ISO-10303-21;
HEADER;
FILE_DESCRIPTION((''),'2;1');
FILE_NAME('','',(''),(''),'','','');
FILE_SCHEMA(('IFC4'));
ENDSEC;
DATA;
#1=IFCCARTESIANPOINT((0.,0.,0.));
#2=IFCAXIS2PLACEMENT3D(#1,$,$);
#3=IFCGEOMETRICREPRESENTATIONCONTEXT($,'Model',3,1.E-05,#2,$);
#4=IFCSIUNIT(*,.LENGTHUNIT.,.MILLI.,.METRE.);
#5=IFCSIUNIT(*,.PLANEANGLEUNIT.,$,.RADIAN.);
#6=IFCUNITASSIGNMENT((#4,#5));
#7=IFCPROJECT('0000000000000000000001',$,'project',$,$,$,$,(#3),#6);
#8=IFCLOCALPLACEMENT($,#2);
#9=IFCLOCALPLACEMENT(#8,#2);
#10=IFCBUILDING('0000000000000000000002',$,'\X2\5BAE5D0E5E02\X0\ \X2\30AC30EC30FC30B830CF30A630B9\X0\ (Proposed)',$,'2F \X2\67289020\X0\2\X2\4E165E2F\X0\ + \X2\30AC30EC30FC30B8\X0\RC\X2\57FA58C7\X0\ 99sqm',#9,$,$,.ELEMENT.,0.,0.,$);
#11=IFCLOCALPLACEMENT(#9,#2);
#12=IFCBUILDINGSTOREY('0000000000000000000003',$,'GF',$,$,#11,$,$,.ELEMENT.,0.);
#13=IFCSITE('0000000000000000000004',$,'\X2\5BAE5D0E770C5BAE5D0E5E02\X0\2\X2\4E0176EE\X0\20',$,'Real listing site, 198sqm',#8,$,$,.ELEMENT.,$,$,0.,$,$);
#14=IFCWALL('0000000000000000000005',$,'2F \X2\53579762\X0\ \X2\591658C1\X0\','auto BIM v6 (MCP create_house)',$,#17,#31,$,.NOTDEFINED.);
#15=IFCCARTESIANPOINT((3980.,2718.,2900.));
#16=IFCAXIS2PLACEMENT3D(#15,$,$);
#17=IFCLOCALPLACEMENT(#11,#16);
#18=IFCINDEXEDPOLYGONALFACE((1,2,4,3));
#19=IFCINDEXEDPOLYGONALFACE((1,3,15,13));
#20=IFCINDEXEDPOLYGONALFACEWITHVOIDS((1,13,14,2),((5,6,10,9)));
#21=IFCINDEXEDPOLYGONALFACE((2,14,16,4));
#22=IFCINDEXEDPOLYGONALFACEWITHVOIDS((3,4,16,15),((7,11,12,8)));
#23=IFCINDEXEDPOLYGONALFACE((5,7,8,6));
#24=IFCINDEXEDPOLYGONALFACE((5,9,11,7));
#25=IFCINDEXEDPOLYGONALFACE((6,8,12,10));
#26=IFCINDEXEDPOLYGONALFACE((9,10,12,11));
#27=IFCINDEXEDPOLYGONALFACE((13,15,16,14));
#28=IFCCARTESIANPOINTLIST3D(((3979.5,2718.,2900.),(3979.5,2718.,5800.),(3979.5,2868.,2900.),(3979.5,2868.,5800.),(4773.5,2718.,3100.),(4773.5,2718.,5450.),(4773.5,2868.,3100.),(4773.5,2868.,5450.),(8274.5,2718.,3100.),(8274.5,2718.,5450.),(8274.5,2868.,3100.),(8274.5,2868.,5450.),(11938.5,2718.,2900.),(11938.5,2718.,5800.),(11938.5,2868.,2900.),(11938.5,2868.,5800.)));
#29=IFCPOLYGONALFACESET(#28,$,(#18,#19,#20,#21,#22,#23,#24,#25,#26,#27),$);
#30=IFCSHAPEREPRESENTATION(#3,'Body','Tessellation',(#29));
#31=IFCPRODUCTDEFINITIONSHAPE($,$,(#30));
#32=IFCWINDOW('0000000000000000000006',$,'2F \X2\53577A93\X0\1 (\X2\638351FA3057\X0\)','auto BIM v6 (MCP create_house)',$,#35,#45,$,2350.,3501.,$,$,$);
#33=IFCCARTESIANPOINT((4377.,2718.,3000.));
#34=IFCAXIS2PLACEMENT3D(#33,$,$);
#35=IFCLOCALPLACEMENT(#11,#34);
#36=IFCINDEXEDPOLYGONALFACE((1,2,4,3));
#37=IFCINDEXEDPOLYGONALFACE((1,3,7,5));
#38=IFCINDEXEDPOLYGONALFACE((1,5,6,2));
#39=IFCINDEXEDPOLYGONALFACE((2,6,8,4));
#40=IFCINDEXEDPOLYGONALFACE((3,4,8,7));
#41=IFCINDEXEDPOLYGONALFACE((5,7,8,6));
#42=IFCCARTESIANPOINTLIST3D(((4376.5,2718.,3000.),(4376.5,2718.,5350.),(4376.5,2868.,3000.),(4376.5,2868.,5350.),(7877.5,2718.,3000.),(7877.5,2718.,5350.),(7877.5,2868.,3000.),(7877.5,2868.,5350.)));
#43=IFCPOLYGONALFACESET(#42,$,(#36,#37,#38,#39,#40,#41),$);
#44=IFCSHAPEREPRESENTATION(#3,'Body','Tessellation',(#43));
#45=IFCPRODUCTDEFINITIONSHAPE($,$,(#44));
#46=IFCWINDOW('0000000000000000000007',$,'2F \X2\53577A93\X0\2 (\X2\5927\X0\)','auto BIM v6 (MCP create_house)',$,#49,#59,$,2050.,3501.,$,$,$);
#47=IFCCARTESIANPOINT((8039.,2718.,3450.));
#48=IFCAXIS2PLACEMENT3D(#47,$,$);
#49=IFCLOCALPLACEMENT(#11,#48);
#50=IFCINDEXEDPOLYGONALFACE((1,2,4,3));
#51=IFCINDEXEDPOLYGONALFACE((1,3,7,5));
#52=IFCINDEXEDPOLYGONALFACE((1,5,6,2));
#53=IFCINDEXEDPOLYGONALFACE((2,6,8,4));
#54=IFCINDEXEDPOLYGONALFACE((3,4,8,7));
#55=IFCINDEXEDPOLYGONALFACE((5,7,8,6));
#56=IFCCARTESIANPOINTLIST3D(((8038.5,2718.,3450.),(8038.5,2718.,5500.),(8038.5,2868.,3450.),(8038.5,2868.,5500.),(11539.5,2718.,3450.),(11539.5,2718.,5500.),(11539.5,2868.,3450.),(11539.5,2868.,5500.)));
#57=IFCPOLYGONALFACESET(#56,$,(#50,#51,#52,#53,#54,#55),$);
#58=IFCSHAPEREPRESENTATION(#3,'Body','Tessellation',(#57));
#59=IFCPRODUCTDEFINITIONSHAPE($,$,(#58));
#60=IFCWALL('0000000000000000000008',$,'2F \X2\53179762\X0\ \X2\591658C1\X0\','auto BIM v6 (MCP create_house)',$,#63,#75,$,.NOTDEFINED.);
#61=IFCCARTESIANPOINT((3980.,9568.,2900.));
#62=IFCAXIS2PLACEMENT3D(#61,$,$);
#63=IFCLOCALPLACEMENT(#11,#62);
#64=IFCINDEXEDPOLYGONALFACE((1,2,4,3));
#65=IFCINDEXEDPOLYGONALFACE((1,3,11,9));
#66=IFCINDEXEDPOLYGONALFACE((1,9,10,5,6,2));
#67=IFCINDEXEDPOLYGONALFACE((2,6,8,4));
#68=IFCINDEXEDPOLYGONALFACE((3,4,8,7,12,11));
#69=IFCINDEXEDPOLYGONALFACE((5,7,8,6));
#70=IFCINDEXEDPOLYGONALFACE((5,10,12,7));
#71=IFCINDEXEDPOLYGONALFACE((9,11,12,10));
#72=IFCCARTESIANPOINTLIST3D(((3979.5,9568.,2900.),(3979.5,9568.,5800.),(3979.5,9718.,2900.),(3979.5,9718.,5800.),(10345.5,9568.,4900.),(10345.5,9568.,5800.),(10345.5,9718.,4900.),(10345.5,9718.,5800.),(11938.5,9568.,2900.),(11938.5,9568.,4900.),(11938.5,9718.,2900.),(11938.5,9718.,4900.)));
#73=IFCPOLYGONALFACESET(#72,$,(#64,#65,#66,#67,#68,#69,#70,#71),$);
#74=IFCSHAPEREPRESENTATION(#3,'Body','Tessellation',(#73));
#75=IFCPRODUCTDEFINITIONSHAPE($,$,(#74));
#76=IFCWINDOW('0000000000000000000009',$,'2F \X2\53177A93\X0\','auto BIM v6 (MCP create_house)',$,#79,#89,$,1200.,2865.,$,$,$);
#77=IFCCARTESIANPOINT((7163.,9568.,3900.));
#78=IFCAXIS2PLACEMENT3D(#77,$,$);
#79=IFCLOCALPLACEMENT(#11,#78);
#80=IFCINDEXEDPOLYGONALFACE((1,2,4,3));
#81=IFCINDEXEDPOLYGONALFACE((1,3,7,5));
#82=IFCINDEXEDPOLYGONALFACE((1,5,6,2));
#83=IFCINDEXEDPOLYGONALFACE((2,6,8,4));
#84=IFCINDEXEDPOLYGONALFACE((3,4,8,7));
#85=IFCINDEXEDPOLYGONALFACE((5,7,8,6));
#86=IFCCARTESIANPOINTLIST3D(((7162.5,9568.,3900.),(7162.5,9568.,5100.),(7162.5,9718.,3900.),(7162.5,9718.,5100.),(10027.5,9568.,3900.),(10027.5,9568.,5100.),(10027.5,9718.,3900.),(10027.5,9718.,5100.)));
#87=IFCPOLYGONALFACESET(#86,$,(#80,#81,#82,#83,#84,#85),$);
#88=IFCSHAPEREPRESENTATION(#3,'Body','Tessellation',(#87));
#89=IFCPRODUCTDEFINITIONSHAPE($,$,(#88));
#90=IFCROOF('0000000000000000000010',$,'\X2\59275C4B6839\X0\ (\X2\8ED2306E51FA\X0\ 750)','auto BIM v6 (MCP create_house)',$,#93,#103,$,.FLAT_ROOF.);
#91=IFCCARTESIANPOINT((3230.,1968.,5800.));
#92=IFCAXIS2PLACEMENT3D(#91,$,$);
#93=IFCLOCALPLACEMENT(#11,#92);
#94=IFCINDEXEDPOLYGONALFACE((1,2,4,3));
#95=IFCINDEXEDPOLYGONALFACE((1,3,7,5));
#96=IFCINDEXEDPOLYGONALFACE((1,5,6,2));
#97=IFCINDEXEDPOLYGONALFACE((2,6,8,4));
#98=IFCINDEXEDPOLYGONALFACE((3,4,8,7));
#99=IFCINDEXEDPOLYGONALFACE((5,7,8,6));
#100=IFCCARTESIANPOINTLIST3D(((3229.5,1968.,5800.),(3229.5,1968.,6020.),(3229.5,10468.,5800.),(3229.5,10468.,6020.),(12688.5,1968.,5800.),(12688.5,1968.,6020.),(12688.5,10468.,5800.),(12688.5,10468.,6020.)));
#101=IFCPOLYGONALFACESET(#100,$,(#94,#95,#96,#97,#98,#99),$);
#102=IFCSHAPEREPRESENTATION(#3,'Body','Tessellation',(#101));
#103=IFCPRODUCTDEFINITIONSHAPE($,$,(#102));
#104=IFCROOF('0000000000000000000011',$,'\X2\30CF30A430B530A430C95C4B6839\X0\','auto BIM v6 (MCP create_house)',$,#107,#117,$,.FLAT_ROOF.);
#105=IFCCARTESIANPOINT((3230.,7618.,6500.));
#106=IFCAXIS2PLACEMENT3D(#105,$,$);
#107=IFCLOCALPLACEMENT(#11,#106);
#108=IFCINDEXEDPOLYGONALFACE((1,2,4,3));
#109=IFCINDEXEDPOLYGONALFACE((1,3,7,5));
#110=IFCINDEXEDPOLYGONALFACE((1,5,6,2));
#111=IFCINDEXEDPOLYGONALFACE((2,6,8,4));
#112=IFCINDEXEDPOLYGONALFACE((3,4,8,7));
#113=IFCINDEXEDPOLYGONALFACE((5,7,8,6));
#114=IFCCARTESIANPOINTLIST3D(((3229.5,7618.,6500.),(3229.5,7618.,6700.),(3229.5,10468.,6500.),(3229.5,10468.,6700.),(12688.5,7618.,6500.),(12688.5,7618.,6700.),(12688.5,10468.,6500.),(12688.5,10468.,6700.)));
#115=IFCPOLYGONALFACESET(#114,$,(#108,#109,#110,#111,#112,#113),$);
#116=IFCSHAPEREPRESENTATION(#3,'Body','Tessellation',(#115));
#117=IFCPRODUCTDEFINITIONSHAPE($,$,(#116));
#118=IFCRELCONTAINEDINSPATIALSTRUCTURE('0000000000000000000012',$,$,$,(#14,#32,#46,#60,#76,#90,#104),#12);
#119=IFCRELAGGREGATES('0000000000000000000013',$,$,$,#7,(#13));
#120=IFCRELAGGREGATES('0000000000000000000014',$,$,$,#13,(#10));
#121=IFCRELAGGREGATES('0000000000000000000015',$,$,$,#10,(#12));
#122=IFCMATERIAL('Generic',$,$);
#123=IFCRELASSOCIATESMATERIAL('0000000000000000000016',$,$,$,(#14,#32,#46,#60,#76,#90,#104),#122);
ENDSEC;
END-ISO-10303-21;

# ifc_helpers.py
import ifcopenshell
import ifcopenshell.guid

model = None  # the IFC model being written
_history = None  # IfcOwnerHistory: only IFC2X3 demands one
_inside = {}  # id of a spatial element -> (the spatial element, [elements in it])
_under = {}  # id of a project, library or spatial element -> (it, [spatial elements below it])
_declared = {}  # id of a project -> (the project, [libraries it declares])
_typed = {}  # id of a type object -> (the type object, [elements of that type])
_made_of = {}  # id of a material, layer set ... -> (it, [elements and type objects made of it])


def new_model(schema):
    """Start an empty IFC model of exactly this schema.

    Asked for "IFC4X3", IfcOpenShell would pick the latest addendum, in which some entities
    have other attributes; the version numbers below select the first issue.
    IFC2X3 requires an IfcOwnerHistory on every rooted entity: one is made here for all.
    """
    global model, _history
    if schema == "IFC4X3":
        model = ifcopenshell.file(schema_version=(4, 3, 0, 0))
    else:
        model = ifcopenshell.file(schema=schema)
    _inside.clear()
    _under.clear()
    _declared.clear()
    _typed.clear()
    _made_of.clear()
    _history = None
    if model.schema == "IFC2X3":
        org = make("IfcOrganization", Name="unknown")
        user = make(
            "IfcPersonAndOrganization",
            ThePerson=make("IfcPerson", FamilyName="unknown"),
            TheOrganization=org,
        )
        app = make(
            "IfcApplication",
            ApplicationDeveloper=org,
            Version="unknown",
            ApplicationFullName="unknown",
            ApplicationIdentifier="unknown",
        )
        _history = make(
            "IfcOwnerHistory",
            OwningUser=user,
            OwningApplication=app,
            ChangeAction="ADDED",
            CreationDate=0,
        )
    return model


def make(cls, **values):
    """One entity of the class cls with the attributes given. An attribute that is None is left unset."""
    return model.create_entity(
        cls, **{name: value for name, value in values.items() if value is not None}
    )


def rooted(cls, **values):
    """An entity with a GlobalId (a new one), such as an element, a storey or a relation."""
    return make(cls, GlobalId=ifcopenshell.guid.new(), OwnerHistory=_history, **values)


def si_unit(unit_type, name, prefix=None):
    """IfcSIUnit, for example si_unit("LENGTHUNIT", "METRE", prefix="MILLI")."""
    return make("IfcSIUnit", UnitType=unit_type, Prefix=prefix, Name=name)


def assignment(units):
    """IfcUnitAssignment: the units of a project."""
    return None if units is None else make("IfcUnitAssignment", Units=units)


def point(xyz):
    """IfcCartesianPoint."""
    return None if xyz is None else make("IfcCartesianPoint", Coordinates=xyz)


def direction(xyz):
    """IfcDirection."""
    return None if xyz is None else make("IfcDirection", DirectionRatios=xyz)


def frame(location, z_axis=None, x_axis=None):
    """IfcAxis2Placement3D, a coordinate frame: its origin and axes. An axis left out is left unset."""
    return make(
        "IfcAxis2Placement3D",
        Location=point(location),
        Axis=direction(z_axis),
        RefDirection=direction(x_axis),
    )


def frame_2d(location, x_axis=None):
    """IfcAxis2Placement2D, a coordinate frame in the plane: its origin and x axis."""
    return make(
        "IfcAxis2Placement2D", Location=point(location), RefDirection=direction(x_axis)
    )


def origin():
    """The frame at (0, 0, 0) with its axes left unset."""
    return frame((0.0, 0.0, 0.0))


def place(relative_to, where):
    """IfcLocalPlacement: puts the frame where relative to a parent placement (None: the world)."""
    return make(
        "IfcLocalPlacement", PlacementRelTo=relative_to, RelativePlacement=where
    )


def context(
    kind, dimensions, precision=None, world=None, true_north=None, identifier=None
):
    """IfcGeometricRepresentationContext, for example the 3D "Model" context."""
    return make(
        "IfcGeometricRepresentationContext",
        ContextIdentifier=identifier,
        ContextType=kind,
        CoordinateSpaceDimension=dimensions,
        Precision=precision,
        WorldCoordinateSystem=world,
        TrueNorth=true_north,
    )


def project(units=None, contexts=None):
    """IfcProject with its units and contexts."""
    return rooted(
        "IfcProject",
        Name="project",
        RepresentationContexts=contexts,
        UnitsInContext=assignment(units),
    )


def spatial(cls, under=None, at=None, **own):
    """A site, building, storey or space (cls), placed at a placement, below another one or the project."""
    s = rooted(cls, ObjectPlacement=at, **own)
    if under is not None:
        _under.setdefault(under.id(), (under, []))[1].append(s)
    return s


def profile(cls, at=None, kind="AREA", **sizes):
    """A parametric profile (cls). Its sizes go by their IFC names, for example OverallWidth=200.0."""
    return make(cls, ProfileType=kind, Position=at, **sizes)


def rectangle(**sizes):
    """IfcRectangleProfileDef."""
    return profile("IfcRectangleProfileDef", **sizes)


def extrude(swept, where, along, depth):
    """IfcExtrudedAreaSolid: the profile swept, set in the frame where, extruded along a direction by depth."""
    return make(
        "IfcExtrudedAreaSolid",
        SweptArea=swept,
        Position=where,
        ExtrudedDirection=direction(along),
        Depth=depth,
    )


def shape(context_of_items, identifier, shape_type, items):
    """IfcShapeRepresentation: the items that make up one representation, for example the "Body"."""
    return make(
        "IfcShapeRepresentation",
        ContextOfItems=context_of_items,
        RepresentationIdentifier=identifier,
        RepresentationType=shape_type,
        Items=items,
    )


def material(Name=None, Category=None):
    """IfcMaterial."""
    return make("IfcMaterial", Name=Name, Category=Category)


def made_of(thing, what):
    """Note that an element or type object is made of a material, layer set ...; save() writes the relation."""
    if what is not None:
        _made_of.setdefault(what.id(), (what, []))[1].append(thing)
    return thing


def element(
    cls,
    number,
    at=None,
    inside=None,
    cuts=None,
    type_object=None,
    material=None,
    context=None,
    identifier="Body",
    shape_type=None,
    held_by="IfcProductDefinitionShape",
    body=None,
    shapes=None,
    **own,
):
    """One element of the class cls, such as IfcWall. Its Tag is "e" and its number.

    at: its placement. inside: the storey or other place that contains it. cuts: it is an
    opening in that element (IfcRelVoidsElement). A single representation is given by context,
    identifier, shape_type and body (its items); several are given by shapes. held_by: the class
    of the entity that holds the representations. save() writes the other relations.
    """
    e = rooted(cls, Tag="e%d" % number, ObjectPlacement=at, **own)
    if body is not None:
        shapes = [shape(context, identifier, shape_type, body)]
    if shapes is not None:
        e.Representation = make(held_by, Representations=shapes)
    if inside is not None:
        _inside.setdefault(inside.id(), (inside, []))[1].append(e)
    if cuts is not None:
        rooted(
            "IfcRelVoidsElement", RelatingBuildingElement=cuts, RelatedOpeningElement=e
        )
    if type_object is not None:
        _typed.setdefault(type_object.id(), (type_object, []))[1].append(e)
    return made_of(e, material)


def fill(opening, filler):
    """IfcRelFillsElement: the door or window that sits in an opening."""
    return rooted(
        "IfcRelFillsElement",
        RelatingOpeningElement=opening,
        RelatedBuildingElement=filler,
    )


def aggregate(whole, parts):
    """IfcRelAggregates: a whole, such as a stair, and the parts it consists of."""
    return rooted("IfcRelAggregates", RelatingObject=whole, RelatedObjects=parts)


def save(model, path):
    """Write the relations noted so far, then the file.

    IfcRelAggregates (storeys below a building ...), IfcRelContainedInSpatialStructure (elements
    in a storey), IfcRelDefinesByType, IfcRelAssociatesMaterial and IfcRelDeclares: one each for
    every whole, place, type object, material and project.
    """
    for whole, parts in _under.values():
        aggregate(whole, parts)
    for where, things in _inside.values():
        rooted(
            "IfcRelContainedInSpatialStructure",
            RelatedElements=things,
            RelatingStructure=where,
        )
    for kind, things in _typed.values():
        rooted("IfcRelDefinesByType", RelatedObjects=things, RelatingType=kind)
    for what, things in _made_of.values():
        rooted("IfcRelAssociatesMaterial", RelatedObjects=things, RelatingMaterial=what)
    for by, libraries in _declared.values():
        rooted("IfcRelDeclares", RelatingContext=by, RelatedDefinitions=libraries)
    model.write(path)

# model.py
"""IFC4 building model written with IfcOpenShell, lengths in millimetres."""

from ifc_helpers import new_model, si_unit, frame, frame_2d, origin, place, context, project, spatial, rectangle, extrude, material, element, fill, save


model = new_model("IFC4")

# Units and contexts
model_context = context("Model", 3, precision=1e-05, world=origin())
ifc_project = project(units=[si_unit("LENGTHUNIT", "METRE", prefix="MILLI"), si_unit("PLANEANGLEUNIT", "RADIAN")], contexts=[model_context])

# Site, building, storey
site_placement = place(None, origin())
site = spatial("IfcSite", under=ifc_project, at=site_placement, Name="宮崎県宮崎市2丁目20", ObjectType="Real listing site, 198sqm", CompositionType="ELEMENT", RefElevation=0.0)
building_placement = place(site_placement, origin())
building = spatial("IfcBuilding", under=site, at=building_placement, Name="宮崎市 ガレージハウス (Proposed)", ObjectType="2F 木造2世帯 + ガレージRC基壇 99sqm", CompositionType="ELEMENT", ElevationOfRefHeight=0.0, ElevationOfTerrain=0.0)
storey_placement = place(building_placement, origin())
storey = spatial("IfcBuildingStorey", under=building, at=storey_placement, Name="GF", CompositionType="ELEMENT", Elevation=0.0)

# Shared definitions
ifc_material = material(Name="Generic")

# Wall, openings, windows
wall_1_placement = place(storey_placement, frame((3980.0, 2718.0, 2900.0)))
wall_1 = element("IfcWall", 1, at=wall_1_placement, inside=storey, material=ifc_material, Name="2F 南面 外壁", Description="auto BIM v6 (MCP create_house)", PredefinedType="NOTDEFINED", context=model_context, shape_type="SweptSolid", body=[
    extrude(rectangle(XDim=7959.0, YDim=150.0, at=frame_2d((3979.0, 75.0))), frame((3980.0, 2718.0, 2900.0)), (0.0, 0.0, 1.0), 2900.0),
])
opening_1_placement = place(storey_placement, frame((4377.0, 2718.0, 3000.0)))
opening_1 = element("IfcOpeningElement", 2, at=opening_1_placement, cuts=wall_1, PredefinedType="NOTDEFINED", context=model_context, shape_type="SweptSolid", body=[
    extrude(rectangle(XDim=3501.0, YDim=150.0, at=frame_2d((1750.0, 75.0))), frame((4377.0, 2718.0, 3000.0)), (0.0, 0.0, 1.0), 2350.0),
])
opening_2_placement = place(storey_placement, frame((8039.0, 2718.0, 3450.0)))
opening_2 = element("IfcOpeningElement", 3, at=opening_2_placement, cuts=wall_1, PredefinedType="NOTDEFINED", context=model_context, shape_type="SweptSolid", body=[
    extrude(rectangle(XDim=3501.0, YDim=150.0, at=frame_2d((1750.0, 75.0))), frame((8039.0, 2718.0, 3450.0)), (0.0, 0.0, 1.0), 2050.0),
])
window_1_placement = place(storey_placement, frame((4377.0, 2718.0, 3000.0)))
window_1 = element("IfcWindow", 4, at=window_1_placement, inside=storey, material=ifc_material, Name="2F 南窓1 (掃出し)", Description="auto BIM v6 (MCP create_house)", OverallHeight=2350.0, OverallWidth=3501.0, context=model_context, shape_type="SweptSolid", body=[
    extrude(rectangle(XDim=3501.0, YDim=150.0, at=frame_2d((1750.0, 75.0))), frame((4377.0, 2718.0, 3000.0)), (0.0, 0.0, 1.0), 2350.0),
])
fill(opening_1, window_1)
window_2_placement = place(storey_placement, frame((8039.0, 2718.0, 3450.0)))
window_2 = element("IfcWindow", 5, at=window_2_placement, inside=storey, material=ifc_material, Name="2F 南窓2 (大)", Description="auto BIM v6 (MCP create_house)", OverallHeight=2050.0, OverallWidth=3501.0, context=model_context, shape_type="SweptSolid", body=[
    extrude(rectangle(XDim=3501.0, YDim=150.0, at=frame_2d((1750.0, 75.0))), frame((8039.0, 2718.0, 3450.0)), (0.0, 0.0, 1.0), 2050.0),
])
fill(opening_2, window_2)

# Wall, opening, window
wall_2_placement = place(storey_placement, frame((3980.0, 9568.0, 2900.0)))
wall_2 = element("IfcWall", 6, at=wall_2_placement, inside=storey, material=ifc_material, Name="2F 北面 外壁", Description="auto BIM v6 (MCP create_house)", PredefinedType="NOTDEFINED", context=model_context, shape_type="SweptSolid", body=[
    extrude(rectangle(XDim=7959.0, YDim=150.0, at=frame_2d((3979.0, 75.0))), frame((3980.0, 9568.0, 2900.0)), (0.0, 0.0, 1.0), 2900.0),
])
opening_3_placement = place(storey_placement, frame((7163.0, 9568.0, 3900.0)))
opening_3 = element("IfcOpeningElement", 7, at=opening_3_placement, cuts=wall_2, PredefinedType="NOTDEFINED", context=model_context, shape_type="SweptSolid", body=[
    extrude(rectangle(XDim=2865.0, YDim=150.0, at=frame_2d((1432.0, 75.0))), frame((7163.0, 9568.0, 3900.0)), (0.0, 0.0, 1.0), 1200.0),
])
window_3_placement = place(storey_placement, frame((7163.0, 9568.0, 3900.0)))
window_3 = element("IfcWindow", 8, at=window_3_placement, inside=storey, material=ifc_material, Name="2F 北窓", Description="auto BIM v6 (MCP create_house)", OverallHeight=1200.0, OverallWidth=2865.0, context=model_context, shape_type="SweptSolid", body=[
    extrude(rectangle(XDim=2865.0, YDim=150.0, at=frame_2d((1432.0, 75.0))), frame((7163.0, 9568.0, 3900.0)), (0.0, 0.0, 1.0), 1200.0),
])
fill(opening_3, window_3)

# Roofs
roof_1_placement = place(storey_placement, frame((3230.0, 1968.0, 5800.0)))
element("IfcRoof", 9, at=roof_1_placement, inside=storey, material=ifc_material, Name="大屋根 (軒の出 750)", Description="auto BIM v6 (MCP create_house)", PredefinedType="FLAT_ROOF", context=model_context, shape_type="SweptSolid", body=[
    extrude(rectangle(XDim=9459.0, YDim=8500.0, at=frame_2d((4729.0, 4250.0))), frame((3230.0, 1968.0, 5800.0)), (0.0, 0.0, 1.0), 220.0),
])
roof_2_placement = place(storey_placement, frame((3230.0, 7618.0, 6500.0)))
element("IfcRoof", 10, at=roof_2_placement, inside=storey, material=ifc_material, Name="ハイサイド屋根", Description="auto BIM v6 (MCP create_house)", PredefinedType="FLAT_ROOF", context=model_context, shape_type="SweptSolid", body=[
    extrude(rectangle(XDim=9459.0, YDim=2850.0, at=frame_2d((4729.0, 1425.0))), frame((3230.0, 7618.0, 6500.0)), (0.0, 0.0, 1.0), 200.0),
])

save(model, "model.ifc")
